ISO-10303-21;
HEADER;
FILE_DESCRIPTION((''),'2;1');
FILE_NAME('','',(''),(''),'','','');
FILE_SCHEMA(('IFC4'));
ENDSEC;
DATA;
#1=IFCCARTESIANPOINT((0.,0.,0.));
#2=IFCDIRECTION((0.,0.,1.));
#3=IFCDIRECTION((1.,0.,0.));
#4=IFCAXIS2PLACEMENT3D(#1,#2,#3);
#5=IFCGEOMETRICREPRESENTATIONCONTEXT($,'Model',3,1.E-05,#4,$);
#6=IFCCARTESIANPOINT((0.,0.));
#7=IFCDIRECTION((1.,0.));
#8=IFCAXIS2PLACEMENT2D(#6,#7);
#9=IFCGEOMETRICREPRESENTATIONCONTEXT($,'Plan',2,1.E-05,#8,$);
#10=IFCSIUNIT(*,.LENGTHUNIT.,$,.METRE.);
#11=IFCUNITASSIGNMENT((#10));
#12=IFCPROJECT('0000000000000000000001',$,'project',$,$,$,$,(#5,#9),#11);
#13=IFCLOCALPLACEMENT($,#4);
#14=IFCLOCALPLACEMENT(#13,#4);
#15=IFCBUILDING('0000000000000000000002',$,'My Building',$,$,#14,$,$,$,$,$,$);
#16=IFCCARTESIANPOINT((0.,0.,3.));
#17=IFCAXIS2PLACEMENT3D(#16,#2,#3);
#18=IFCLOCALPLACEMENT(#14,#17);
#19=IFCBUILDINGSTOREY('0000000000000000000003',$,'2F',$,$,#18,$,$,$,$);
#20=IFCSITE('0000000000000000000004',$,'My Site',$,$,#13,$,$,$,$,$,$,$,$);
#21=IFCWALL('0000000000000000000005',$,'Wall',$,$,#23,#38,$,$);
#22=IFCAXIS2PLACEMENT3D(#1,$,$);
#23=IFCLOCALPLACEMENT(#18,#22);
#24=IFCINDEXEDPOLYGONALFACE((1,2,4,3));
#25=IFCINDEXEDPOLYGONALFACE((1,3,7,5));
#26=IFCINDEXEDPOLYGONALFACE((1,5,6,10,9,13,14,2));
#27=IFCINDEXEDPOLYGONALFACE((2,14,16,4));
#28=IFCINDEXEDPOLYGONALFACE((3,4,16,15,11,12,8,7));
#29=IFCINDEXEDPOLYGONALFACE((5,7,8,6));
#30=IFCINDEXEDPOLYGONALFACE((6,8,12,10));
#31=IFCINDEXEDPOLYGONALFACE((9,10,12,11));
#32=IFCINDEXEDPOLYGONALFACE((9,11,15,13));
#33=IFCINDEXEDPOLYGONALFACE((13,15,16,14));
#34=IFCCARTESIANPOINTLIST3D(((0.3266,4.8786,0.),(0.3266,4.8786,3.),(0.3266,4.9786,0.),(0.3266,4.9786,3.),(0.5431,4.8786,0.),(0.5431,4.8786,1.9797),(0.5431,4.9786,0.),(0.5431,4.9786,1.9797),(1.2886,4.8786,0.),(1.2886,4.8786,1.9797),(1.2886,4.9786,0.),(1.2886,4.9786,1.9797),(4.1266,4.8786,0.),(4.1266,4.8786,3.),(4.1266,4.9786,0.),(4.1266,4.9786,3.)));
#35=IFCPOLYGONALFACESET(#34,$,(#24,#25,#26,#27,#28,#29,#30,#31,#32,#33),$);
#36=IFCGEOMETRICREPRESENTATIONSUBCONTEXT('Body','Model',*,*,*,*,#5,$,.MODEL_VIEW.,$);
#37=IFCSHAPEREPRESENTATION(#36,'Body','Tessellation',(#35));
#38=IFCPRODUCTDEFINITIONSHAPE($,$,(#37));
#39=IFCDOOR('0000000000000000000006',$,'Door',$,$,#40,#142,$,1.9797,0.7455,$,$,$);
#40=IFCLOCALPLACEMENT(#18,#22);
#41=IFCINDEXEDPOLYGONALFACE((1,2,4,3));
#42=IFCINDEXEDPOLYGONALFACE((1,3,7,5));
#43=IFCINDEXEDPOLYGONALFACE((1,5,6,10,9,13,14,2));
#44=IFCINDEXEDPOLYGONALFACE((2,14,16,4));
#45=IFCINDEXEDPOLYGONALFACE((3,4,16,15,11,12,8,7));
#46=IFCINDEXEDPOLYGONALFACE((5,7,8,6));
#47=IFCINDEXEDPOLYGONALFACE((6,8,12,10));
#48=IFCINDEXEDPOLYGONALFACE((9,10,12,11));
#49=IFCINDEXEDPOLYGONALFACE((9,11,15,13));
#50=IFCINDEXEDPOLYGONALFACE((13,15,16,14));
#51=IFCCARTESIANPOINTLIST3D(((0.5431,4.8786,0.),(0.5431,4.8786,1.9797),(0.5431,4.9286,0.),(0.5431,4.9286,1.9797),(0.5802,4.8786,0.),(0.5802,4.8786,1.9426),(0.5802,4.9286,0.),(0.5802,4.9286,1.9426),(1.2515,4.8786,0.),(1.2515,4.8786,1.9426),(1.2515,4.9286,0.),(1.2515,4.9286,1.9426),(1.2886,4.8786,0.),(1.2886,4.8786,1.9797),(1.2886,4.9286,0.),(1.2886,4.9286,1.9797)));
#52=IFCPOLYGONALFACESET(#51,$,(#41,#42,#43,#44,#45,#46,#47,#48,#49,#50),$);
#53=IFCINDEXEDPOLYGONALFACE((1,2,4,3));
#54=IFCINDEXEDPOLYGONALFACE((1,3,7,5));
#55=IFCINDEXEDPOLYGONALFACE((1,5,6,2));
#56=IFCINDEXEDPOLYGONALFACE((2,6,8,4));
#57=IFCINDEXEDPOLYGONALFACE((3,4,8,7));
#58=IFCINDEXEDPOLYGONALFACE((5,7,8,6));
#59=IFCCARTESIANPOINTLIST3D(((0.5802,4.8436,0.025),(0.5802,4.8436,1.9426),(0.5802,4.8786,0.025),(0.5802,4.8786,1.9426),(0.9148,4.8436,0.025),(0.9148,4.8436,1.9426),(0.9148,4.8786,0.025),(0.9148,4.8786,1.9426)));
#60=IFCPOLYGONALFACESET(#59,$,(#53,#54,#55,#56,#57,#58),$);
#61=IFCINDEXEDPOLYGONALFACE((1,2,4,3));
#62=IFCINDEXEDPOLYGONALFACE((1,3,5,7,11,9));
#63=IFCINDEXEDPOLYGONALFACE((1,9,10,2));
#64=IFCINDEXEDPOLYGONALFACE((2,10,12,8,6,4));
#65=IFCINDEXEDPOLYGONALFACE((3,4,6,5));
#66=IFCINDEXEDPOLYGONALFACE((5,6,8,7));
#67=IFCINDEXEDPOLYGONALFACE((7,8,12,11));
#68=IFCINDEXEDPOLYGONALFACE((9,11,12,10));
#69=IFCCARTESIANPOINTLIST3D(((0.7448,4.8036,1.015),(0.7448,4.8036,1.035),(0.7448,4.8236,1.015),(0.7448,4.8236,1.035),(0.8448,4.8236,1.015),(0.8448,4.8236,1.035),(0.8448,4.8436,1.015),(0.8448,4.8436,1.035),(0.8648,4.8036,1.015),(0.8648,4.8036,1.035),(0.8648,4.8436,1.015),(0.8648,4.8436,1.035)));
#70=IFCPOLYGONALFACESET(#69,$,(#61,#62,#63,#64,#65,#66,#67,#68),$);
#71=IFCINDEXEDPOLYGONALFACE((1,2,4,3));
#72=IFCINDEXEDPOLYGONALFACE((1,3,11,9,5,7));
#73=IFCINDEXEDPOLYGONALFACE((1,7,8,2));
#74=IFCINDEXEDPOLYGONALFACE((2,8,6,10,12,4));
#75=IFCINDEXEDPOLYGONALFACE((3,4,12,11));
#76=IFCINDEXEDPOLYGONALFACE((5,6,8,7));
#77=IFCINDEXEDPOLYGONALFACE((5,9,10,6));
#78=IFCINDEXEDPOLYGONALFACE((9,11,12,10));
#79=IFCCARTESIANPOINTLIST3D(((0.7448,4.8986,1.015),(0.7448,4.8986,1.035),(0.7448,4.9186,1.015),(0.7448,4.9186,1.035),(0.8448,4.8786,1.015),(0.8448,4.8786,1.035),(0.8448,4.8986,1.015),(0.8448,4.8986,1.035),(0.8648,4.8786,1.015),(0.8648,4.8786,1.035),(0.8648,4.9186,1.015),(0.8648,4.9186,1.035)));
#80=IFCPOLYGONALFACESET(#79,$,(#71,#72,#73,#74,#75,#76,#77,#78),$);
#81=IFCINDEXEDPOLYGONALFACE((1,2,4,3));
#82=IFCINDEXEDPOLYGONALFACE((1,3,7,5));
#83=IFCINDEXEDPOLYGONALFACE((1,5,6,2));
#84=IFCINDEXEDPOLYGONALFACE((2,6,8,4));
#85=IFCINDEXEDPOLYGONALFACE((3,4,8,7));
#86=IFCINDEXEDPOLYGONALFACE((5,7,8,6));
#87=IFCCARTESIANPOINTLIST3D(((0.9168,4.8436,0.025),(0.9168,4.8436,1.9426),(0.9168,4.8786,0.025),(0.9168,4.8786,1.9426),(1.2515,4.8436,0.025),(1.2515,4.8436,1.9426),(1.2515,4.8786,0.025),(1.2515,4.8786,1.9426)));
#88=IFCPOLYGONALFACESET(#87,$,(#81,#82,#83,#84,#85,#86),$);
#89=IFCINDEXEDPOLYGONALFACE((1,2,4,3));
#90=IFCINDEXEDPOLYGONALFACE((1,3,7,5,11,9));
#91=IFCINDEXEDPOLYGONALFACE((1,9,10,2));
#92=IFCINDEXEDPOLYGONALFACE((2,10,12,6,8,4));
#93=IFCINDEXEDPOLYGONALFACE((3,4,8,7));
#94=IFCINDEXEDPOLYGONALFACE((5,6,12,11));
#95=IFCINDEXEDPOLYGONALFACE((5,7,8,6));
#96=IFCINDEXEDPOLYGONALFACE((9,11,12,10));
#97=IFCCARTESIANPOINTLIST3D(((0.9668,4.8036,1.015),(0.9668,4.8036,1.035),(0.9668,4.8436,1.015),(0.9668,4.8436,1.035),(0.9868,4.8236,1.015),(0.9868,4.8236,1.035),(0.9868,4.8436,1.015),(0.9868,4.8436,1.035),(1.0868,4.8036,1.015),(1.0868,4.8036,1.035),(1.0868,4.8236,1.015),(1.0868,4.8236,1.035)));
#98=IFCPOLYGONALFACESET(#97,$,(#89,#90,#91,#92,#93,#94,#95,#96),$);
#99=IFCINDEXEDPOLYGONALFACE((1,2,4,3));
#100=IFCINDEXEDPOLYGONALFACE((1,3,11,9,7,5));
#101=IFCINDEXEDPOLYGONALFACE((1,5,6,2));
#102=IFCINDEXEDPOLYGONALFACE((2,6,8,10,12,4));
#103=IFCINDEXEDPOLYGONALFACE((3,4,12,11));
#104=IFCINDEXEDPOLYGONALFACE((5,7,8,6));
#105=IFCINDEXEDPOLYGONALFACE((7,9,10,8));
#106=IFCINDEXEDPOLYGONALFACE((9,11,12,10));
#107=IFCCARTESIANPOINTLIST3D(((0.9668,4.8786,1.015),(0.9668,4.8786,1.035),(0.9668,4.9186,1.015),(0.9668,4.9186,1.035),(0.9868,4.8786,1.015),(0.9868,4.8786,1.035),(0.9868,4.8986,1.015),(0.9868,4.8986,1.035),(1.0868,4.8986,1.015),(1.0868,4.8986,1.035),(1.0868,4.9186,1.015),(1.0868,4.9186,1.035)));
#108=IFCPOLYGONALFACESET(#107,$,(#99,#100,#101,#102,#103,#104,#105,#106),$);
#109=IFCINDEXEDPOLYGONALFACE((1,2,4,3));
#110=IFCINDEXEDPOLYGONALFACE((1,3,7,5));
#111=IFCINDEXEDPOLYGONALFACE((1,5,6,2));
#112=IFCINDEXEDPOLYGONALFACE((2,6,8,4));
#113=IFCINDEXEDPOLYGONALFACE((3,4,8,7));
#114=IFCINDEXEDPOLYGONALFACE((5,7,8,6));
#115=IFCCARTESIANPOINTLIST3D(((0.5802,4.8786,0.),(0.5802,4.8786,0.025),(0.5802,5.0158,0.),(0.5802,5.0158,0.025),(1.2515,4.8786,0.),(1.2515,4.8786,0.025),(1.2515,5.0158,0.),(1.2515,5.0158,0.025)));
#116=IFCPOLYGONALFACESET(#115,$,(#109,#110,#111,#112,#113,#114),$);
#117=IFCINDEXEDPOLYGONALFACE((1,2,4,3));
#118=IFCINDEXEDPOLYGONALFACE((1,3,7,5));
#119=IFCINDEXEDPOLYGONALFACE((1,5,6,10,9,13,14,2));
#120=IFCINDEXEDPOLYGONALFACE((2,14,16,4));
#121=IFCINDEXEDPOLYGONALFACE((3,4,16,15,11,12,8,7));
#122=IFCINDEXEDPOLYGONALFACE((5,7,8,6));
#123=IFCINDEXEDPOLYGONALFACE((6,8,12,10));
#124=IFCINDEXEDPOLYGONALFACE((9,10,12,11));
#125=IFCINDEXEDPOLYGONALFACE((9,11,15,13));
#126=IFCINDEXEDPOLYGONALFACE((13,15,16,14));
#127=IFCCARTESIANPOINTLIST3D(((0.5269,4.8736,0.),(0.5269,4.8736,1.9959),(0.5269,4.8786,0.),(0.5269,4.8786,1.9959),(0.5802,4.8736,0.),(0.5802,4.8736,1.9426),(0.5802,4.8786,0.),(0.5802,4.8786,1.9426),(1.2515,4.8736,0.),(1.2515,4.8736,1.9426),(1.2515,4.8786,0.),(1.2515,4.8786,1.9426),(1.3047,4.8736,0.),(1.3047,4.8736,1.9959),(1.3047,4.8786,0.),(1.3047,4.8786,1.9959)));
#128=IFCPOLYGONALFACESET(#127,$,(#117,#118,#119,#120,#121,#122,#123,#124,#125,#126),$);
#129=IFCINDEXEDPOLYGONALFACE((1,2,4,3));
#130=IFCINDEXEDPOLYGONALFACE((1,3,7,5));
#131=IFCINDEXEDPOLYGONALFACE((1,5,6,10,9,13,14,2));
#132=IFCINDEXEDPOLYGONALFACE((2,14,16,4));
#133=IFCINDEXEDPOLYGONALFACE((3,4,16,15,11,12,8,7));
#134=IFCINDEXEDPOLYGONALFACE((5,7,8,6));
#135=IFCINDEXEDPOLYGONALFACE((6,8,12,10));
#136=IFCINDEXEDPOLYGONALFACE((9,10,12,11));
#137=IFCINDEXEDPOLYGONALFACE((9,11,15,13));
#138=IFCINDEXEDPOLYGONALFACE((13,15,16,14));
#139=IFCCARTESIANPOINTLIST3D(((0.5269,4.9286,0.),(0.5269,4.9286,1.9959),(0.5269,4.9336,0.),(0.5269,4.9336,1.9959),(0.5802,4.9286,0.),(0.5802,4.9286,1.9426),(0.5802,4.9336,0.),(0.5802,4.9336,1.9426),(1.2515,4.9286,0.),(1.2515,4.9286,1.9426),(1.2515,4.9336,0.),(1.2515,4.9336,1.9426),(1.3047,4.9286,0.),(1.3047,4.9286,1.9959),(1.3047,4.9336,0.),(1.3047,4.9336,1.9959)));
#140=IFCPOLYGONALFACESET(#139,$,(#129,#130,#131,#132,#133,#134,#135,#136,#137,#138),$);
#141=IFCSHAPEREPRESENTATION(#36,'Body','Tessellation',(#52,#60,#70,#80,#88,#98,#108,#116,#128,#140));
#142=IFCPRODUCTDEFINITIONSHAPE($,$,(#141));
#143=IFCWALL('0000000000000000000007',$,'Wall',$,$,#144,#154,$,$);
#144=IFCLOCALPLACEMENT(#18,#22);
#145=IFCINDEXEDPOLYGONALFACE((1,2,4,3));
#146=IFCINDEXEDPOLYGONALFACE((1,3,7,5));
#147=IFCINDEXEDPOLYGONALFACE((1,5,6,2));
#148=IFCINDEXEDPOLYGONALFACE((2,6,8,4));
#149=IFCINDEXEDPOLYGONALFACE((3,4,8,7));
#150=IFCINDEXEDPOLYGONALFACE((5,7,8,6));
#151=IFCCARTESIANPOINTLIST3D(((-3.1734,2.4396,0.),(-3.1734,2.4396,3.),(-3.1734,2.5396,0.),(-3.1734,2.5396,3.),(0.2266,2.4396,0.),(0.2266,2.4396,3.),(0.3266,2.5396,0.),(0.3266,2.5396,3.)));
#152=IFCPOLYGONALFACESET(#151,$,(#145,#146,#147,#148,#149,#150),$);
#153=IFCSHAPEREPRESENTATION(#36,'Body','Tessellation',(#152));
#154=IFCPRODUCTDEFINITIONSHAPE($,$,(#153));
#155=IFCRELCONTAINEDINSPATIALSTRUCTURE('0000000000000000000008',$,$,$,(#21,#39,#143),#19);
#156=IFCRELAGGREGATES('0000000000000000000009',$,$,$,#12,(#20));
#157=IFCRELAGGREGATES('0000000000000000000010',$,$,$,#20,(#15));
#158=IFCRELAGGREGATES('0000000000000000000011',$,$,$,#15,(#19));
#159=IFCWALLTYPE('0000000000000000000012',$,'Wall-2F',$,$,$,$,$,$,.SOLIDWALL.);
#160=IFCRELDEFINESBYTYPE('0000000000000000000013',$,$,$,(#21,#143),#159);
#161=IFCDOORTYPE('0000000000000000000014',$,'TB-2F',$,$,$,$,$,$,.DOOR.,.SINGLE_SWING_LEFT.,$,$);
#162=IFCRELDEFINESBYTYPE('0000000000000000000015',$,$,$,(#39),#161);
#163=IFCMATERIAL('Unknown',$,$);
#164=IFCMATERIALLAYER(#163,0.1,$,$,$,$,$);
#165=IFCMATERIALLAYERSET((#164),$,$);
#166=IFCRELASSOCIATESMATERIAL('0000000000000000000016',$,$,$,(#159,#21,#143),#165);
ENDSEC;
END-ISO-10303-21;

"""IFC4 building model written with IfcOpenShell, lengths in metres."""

from ifc_helpers import new_model, entity, si_unit, frame, origin_with_axes, origin_2d_with_axis, place, context, subcontext, project, spatial, line, indexed_curve, outline, extrude, shape, source, transform, mapped, material, layer, layer_set, layer_usage, type_object, type_shapes, element, fill, save


model = new_model("IFC4")

# Units and contexts
model_context = context("Model", 3, precision=1e-05, world=origin_with_axes())
plan_context = context("Plan", 2, precision=1e-05, world=origin_2d_with_axis())
body_context_1 = subcontext(model_context, "Body", "Model", "MODEL_VIEW")
body_context_2 = subcontext(plan_context, "Body", "Plan", "PLAN_VIEW")
ifc_project = project(units=[si_unit("LENGTHUNIT", "METRE")], contexts=[model_context, plan_context])

# Site, building, storey
site_placement = place(None, origin_with_axes())
site = spatial("IfcSite", under=ifc_project, at=site_placement, Name="My Site")
building_placement = place(site_placement, origin_with_axes())
building = spatial("IfcBuilding", under=site, at=building_placement, Name="My Building")
storey_placement = place(building_placement, frame((0.0, 0.0, 3.0), z_axis=(0.0, 0.0, 1.0), x_axis=(1.0, 0.0, 0.0)))
storey = spatial("IfcBuildingStorey", under=building, at=storey_placement, Name="2F")

# Shared definitions
ifc_material = material(Name="Unknown")

# Shared definitions
ifc_layer_1 = layer(ifc_material, 0.1)
ifc_layer_set_1 = layer_set([ifc_layer_1])
wall_type = type_object("IfcWallType", Name="Wall-2F", PredefinedType="SOLIDWALL", material=ifc_layer_set_1)

# Wall, opening, door
ifc_layer_usage_1 = layer_usage(ifc_layer_set_1, "AXIS2", "POSITIVE", 0.0)
wall_1_placement = place(storey_placement, frame((4.2266, 4.9786, 0.0), z_axis=(0.0, 0.0, 1.0), x_axis=(-1.0, 0.0, 0.0)))
wall_1 = element("IfcWall", 1, at=wall_1_placement, inside=storey, type_object=wall_type, material=ifc_layer_usage_1, Name="Wall", context=body_context_1, shape_type="SweptSolid", body=[
    extrude(outline(indexed_curve([(0.1, 0.0), (0.1, 0.1), (3.9, 0.1), (3.9, 0.0)], segments=[line(1, 2, 3, 4, 1)])), origin_with_axes(), (0.0, 0.0, 1.0), 3.0),
])
shared_shape_1 = source(origin_with_axes(), body_context_1, "Body", "SweptSolid", [
    extrude(outline(indexed_curve([(0.0, 0.0), (0.7455, 0.0), (0.7455, 1.9797), (0.0, 1.9797)], segments=[line(1, 2, 3, 4, 1)])), frame((0.0, -0.6, 0.0), z_axis=(0.0, -1.0, 0.0), x_axis=(1.0, 0.0, 0.0)), (0.0, 0.0, -1.0), 1.2),
])
opening_1_placement = place(wall_1_placement, frame((3.6835, 0.1, 0.0), z_axis=(0.0, 0.0, 1.0), x_axis=(-1.0, 0.0, 0.0)))
opening_1 = element("IfcOpeningElement", 2, at=opening_1_placement, cuts=wall_1, PredefinedType="OPENING", context=body_context_1, shape_type="MappedRepresentation", body=[
    mapped(shared_shape_1, transform((0.0, 0.0, 0.0), x_axis=(1.0, 0.0, 0.0), y_axis=(0.0, 1.0, 0.0), z_axis=(0.0, 0.0, 1.0), scale=1.0)),
])
door_type_1 = type_object("IfcDoorType", Name="TB-2F", OperationType="SINGLE_SWING_LEFT", PredefinedType="DOOR")
shared_shape_2 = source(origin_with_axes(), body_context_1, "Body", "SweptSolid", [
    extrude(outline(indexed_curve([(0.0, 0.0), (0.0, 1.9797), (0.7455, 1.9797), (0.7455, 0.0), (0.7084, 0.0), (0.7084, 1.9426), (0.0371, 1.9426), (0.0371, 0.0)], segments=[line(1, 2, 3, 4, 5, 6, 7, 8, 1)])), frame((0.0, 0.0, 0.0), z_axis=(0.0, -1.0, 0.0), x_axis=(1.0, 0.0, 0.0)), (0.0, 0.0, -1.0), 0.05),
    extrude(outline(indexed_curve([(0.0, 0.0), (0.3347, 0.0), (0.3347, 0.035), (0.0, 0.035)], segments=[line(1, 2, 3, 4, 1)])), frame((0.0371, -0.035, 0.025), z_axis=(0.0, 0.0, 1.0), x_axis=(1.0, 0.0, 0.0)), (0.0, 0.0, 1.0), 1.9176),
    extrude(outline(indexed_curve([(0.0, 0.0), (0.0, -0.04), (-0.12, -0.04), (-0.12, -0.02), (-0.02, -0.02), (-0.02, 0.0)], segments=[line(1, 2, 3, 4, 5, 6, 1)])), frame((0.3218, -0.035, 1.015), z_axis=(0.0, 0.0, 1.0), x_axis=(1.0, 0.0, 0.0)), (0.0, 0.0, 1.0), 0.02),
    extrude(outline(indexed_curve([(0.0, 0.0), (0.0, 0.04), (-0.12, 0.04), (-0.12, 0.02), (-0.02, 0.02), (-0.02, 0.0)], segments=[line(1, 2, 3, 4, 5, 6, 1)])), frame((0.3218, 0.0, 1.015), z_axis=(0.0, 0.0, 1.0), x_axis=(1.0, 0.0, 0.0)), (0.0, 0.0, 1.0), 0.02),
    extrude(outline(indexed_curve([(0.0, 0.0), (-0.3347, 0.0), (-0.3347, 0.035), (0.0, 0.035)], segments=[line(1, 2, 3, 4, 1)])), frame((0.7084, -0.035, 0.025), z_axis=(0.0, 0.0, 1.0), x_axis=(1.0, 0.0, 0.0)), (0.0, 0.0, 1.0), 1.9176),
    extrude(outline(indexed_curve([(0.0, 0.0), (0.0, -0.04), (0.12, -0.04), (0.12, -0.02), (0.02, -0.02), (0.02, 0.0)], segments=[line(1, 2, 3, 4, 5, 6, 1)])), frame((0.4238, -0.035, 1.015), z_axis=(0.0, 0.0, 1.0), x_axis=(1.0, 0.0, 0.0)), (0.0, 0.0, 1.0), 0.02),
    extrude(outline(indexed_curve([(0.0, 0.0), (0.0, 0.04), (0.12, 0.04), (0.12, 0.02), (0.02, 0.02), (0.02, 0.0)], segments=[line(1, 2, 3, 4, 5, 6, 1)])), frame((0.4238, 0.0, 1.015), z_axis=(0.0, 0.0, 1.0), x_axis=(1.0, 0.0, 0.0)), (0.0, 0.0, 1.0), 0.02),
    extrude(outline(indexed_curve([(0.0, 0.0), (0.6713, 0.0), (0.6713, 0.1372), (0.0, 0.1372)], segments=[line(1, 2, 3, 4, 1)])), frame((0.0371, 0.0, 0.0), z_axis=(0.0, 0.0, 1.0), x_axis=(1.0, 0.0, 0.0)), (0.0, 0.0, 1.0), 0.025),
    extrude(outline(indexed_curve([(0.0, 0.0), (0.0, 1.9959), (0.7778, 1.9959), (0.7778, 0.0), (0.7246, 0.0), (0.7246, 1.9426), (0.0532, 1.9426), (0.0532, 0.0)], segments=[line(1, 2, 3, 4, 5, 6, 7, 8, 1)])), frame((-0.0162, -0.005, 0.0), z_axis=(0.0, -1.0, 0.0), x_axis=(1.0, 0.0, 0.0)), (0.0, 0.0, -1.0), 0.005),
    extrude(outline(indexed_curve([(0.0, 0.0), (0.0, 1.9959), (0.7778, 1.9959), (0.7778, 0.0), (0.7246, 0.0), (0.7246, 1.9426), (0.0532, 1.9426), (0.0532, 0.0)], segments=[line(1, 2, 3, 4, 5, 6, 7, 8, 1)])), frame((-0.0162, 0.05, 0.0), z_axis=(0.0, -1.0, 0.0), x_axis=(1.0, 0.0, 0.0)), (0.0, 0.0, -1.0), 0.005),
])
shared_shape_3 = source(origin_with_axes(), body_context_2, "Body", "Curve2D", [
    entity("IfcIndexedPolyCurve", entity("IfcCartesianPointList2D", [[0.0, 0.0], [0.0371, 0.0], [0.0371, 0.05], [0.0, 0.05]]), [entity("IfcLineIndex", [1, 2, 3, 4, 1])]),
    entity("IfcIndexedPolyCurve", entity("IfcCartesianPointList2D", [[0.7455, 0.0], [0.7084, 0.0], [0.7084, 0.05], [0.7455, 0.05]]), [entity("IfcLineIndex", [1, 2, 3, 4, 1])]),
    entity("IfcIndexedPolyCurve", entity("IfcCartesianPointList2D", [[-0.1307, -0.035], [0.2049, -0.035], [0.2049, 0.0], [-0.1307, 0.0]]), [entity("IfcLineIndex", [1, 2, 3, 4, 1])]),
    entity("IfcIndexedPolyCurve", entity("IfcCartesianPointList2D", [[0.8763, -0.035], [0.5406, -0.035], [0.5406, 0.0], [0.8763, 0.0]]), [entity("IfcLineIndex", [1, 2, 3, 4, 1])]),
])
type_shapes(door_type_1, [shared_shape_2, shared_shape_3])
door_1_placement = place(opening_1_placement, frame((0.0, 0.0, 0.0), z_axis=(0.0, 0.0, 1.0), x_axis=(1.0, 0.0, 0.0)))
door_1 = element("IfcDoor", 3, at=door_1_placement, inside=storey, type_object=door_type_1, Name="Door", OverallHeight=1.9797, OverallWidth=0.7455, shapes=[
    shape(body_context_1, "Body", "MappedRepresentation", [mapped(shared_shape_2, transform((0.0, 0.0, 0.0), x_axis=(1.0, 0.0, 0.0), y_axis=(0.0, 1.0, 0.0), z_axis=(0.0, 0.0, 1.0), scale=1.0))]),
    shape(body_context_2, "Body", "MappedRepresentation", [mapped(shared_shape_3, transform((0.0, 0.0, 0.0), x_axis=(1.0, 0.0, 0.0), y_axis=(0.0, 1.0, 0.0), z_axis=(0.0, 0.0, 1.0), scale=1.0))]),
])
fill(opening_1, door_1)

# Wall
ifc_layer_usage_2 = layer_usage(ifc_layer_set_1, "AXIS2", "POSITIVE", 0.0)
wall_2_placement = place(storey_placement, frame((-3.1734, 2.4396, 0.0), z_axis=(0.0, 0.0, 1.0), x_axis=(1.0, 0.0, 0.0)))
element("IfcWall", 4, at=wall_2_placement, inside=storey, type_object=wall_type, material=ifc_layer_usage_2, Name="Wall", context=body_context_1, shape_type="SweptSolid", body=[
    extrude(outline(indexed_curve([(0.0, 0.0), (0.0, 0.1), (3.5, 0.1), (3.4, 0.0)], segments=[line(1, 2, 3, 4, 1)])), origin_with_axes(), (0.0, 0.0, 1.0), 3.0),
])

save(model, "model.ifc")
